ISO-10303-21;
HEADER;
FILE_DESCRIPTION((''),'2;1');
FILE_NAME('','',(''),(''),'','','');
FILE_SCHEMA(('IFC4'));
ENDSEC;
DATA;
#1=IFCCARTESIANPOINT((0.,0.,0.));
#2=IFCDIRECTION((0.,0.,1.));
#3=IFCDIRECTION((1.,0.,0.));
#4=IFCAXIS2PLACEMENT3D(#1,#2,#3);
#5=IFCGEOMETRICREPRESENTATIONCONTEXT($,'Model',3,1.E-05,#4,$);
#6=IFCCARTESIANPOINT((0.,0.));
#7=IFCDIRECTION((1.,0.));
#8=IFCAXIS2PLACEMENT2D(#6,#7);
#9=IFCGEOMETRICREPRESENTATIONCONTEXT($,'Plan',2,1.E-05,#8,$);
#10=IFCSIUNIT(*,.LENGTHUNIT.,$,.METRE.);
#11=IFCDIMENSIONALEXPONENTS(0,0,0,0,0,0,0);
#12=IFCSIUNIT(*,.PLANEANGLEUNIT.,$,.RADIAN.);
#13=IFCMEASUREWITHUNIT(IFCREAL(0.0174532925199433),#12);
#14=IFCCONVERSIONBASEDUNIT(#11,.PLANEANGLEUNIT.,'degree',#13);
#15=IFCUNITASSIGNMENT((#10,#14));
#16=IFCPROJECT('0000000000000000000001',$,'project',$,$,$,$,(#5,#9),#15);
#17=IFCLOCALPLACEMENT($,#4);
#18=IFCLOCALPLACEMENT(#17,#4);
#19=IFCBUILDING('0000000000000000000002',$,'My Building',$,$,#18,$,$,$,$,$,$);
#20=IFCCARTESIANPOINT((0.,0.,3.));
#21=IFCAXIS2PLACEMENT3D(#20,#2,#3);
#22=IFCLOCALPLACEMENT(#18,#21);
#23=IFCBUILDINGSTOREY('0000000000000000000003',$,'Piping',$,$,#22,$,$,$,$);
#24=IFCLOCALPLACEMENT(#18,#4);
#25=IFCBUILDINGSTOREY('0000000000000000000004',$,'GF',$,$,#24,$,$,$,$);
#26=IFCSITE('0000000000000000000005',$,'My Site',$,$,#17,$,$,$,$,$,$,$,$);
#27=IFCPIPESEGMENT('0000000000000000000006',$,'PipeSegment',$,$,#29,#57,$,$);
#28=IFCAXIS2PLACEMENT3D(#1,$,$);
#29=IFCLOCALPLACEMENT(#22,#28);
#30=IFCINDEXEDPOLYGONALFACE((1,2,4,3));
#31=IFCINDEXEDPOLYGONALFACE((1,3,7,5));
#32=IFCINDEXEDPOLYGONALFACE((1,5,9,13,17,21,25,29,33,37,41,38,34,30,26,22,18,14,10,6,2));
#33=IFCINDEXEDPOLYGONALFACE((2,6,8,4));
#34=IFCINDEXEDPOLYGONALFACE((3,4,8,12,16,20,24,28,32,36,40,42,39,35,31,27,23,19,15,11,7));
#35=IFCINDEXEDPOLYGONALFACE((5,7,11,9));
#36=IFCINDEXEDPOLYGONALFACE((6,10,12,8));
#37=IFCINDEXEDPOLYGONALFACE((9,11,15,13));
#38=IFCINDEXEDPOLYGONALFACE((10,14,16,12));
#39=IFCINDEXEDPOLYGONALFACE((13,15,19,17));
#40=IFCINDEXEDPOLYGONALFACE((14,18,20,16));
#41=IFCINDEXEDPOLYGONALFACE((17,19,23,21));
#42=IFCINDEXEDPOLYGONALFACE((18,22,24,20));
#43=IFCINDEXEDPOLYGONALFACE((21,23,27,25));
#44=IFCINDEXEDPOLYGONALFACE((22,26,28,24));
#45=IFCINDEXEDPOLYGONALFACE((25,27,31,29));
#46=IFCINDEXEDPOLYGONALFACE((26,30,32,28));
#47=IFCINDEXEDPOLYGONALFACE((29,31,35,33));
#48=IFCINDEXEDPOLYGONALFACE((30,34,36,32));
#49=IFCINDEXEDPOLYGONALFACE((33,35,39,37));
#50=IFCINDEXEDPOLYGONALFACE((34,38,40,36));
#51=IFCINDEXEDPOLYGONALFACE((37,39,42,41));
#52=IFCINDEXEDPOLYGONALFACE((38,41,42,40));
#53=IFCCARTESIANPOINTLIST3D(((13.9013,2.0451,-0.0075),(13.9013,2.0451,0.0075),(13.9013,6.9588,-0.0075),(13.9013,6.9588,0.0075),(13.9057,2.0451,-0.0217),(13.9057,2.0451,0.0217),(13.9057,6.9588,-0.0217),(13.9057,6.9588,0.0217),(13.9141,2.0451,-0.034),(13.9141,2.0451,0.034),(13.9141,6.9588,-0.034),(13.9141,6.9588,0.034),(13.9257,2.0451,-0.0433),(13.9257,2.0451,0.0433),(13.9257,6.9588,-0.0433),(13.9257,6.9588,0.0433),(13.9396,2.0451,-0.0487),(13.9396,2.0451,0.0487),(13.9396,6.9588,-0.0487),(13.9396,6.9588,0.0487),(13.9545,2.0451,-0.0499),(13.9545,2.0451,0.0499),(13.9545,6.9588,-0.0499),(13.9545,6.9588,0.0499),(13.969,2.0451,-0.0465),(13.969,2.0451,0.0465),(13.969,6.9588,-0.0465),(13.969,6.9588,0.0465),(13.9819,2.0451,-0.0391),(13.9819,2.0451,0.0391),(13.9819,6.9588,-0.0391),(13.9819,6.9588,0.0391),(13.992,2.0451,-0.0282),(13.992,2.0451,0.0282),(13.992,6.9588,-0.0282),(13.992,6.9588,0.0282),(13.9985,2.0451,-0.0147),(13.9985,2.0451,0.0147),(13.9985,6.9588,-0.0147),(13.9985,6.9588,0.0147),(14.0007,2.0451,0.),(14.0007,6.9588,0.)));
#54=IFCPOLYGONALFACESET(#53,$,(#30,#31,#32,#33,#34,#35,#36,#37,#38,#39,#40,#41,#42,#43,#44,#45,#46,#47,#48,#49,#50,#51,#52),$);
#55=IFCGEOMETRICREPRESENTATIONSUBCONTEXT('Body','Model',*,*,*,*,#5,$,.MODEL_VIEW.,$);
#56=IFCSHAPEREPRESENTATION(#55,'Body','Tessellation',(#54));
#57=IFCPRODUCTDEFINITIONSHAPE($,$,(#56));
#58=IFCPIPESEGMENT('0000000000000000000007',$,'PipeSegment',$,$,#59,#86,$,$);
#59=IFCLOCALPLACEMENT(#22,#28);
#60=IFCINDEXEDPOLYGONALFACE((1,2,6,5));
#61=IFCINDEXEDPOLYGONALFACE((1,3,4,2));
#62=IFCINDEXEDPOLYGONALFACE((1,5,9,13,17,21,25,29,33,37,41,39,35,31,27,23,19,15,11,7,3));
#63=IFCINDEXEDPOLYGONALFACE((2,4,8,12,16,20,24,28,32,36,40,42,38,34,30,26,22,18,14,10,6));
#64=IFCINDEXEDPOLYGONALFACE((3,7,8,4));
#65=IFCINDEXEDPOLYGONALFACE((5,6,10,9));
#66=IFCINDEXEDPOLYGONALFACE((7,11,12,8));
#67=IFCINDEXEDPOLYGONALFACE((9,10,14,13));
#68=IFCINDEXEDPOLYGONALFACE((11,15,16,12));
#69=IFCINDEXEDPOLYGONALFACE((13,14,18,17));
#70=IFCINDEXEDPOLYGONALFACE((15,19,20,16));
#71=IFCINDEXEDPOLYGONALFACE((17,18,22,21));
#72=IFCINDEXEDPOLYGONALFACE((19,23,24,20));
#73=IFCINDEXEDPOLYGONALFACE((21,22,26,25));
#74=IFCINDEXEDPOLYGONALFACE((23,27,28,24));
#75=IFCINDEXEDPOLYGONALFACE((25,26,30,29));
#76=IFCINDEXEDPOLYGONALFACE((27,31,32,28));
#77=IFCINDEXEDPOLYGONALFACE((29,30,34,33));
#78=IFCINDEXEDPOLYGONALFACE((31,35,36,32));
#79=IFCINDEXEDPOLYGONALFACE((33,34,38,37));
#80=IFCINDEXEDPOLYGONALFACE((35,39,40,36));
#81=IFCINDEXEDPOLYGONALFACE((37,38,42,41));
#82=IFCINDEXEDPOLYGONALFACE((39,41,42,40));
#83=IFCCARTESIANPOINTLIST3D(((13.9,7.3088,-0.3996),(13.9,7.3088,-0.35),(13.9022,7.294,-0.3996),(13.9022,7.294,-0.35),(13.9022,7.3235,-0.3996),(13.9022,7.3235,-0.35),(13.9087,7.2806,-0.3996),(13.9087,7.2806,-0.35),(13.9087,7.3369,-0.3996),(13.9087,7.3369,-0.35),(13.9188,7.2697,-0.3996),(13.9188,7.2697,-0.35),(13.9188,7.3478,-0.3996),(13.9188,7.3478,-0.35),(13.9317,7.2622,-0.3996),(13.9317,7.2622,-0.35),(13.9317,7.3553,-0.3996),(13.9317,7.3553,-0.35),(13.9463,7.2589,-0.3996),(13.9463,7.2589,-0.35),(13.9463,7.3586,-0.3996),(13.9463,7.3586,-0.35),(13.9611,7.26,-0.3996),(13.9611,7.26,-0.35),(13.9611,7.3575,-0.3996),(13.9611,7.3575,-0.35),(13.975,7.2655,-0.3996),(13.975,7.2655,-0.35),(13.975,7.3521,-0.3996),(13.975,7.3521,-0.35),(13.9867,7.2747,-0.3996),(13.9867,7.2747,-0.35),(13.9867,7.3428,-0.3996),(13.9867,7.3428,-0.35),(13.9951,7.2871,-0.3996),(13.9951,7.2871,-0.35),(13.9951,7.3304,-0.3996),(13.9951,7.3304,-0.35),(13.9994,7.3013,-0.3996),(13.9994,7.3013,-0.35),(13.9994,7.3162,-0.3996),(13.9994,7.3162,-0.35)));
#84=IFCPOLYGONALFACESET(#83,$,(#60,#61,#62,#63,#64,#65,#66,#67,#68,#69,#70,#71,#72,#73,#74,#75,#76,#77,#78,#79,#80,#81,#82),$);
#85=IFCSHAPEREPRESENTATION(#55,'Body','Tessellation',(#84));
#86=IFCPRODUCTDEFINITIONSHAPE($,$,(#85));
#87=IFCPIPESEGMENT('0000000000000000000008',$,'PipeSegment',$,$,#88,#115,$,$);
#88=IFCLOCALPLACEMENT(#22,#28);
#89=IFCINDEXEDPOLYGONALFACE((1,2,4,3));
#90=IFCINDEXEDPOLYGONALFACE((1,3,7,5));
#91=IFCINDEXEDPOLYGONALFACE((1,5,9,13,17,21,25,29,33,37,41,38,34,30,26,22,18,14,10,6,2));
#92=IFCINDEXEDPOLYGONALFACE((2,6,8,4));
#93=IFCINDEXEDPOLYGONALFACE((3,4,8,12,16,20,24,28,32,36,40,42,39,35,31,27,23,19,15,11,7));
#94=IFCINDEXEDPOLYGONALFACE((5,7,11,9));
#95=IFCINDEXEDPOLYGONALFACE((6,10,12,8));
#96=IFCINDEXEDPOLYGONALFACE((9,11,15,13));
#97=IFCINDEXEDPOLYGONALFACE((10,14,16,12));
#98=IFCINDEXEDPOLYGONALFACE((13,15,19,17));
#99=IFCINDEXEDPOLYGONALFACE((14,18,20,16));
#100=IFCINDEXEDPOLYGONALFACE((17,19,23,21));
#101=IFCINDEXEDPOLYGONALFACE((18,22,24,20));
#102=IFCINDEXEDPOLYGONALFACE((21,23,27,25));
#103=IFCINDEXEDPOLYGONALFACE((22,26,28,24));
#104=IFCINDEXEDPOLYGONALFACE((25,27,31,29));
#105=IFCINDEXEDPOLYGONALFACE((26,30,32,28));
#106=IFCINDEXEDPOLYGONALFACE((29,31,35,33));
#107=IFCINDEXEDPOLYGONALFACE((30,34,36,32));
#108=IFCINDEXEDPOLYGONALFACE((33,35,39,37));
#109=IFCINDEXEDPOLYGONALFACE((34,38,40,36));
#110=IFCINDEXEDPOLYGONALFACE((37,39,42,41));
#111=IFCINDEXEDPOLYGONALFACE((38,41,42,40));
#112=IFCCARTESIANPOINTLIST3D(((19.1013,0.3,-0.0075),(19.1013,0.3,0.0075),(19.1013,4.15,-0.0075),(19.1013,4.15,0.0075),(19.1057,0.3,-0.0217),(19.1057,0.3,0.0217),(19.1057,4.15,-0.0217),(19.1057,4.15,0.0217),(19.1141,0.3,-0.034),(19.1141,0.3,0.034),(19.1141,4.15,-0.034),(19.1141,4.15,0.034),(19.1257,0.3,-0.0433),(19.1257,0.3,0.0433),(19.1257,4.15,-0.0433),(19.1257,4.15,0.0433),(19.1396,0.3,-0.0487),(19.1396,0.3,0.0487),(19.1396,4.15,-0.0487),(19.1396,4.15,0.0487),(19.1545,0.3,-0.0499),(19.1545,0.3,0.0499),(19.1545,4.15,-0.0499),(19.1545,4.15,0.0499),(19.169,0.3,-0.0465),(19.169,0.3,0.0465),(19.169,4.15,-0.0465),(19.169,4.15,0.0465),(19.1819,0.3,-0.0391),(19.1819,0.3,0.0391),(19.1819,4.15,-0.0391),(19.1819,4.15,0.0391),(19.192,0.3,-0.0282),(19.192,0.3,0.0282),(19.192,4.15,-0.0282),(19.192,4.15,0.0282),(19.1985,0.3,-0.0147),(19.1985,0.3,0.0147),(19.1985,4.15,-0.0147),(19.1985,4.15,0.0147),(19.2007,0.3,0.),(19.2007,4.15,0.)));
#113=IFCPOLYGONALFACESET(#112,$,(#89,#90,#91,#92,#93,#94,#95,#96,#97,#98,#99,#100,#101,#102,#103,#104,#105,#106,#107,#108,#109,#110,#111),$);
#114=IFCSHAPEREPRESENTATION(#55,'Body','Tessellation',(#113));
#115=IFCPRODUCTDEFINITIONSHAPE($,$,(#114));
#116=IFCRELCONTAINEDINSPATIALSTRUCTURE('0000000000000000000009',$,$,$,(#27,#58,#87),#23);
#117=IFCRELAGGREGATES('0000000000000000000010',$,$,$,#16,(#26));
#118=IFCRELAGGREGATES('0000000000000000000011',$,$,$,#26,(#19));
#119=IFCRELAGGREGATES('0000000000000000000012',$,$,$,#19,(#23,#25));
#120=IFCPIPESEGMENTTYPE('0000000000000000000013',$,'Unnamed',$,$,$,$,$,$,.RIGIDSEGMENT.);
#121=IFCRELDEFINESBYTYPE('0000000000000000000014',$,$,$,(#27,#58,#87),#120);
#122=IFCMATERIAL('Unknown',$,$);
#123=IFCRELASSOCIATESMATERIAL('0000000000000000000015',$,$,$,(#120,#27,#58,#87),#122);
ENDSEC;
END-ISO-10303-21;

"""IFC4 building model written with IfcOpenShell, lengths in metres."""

from ifc_helpers import new_model, entity, si_unit, converted_unit, frame, origin_with_axes, origin_2d_with_axis, place, context, subcontext, project, spatial, circle, extrude, material, material_profile, profile_set, profile_usage, type_object, element, save


model = new_model("IFC4")

# Units and contexts
model_context = context("Model", 3, precision=1e-05, world=origin_with_axes())
plan_context = context("Plan", 2, precision=1e-05, world=origin_2d_with_axis())
body_context_1 = subcontext(model_context, "Body", "Model", "MODEL_VIEW")
ifc_project = project(units=[si_unit("LENGTHUNIT", "METRE"), converted_unit("PLANEANGLEUNIT", "degree", entity("IfcReal", 0.0174532925199433), si_unit("PLANEANGLEUNIT", "RADIAN"), dimensions=[0, 0, 0, 0, 0, 0, 0])], contexts=[model_context, plan_context])

# Site, building, storey
site_placement = place(None, origin_with_axes())
site = spatial("IfcSite", under=ifc_project, at=site_placement, Name="My Site")
building_placement = place(site_placement, origin_with_axes())
building = spatial("IfcBuilding", under=site, at=building_placement, Name="My Building")
storey_1_placement = place(building_placement, frame((0.0, 0.0, 3.0), z_axis=(0.0, 0.0, 1.0), x_axis=(1.0, 0.0, 0.0)))
storey_1 = spatial("IfcBuildingStorey", under=building, at=storey_1_placement, Name="Piping")

# Shared definitions
ifc_material = material(Name="Unknown")

# Shared definitions
storey_2_placement = place(building_placement, origin_with_axes())
storey_2 = spatial("IfcBuildingStorey", under=building, at=storey_2_placement, Name="GF")

# Pipe segments
ifc_material_profile = material_profile(ifc_material, circle(Radius=0.05))
ifc_profile_set = profile_set([ifc_material_profile])
pipe_segment_type = type_object("IfcPipeSegmentType", Name="Unnamed", PredefinedType="RIGIDSEGMENT", material=ifc_profile_set)
ifc_profile_usage_1 = profile_usage(ifc_profile_set, cardinal=5)
pipe_segment_1_placement = place(storey_1_placement, frame((13.9507, 6.9588, 0.0), z_axis=(0.0, -1.0, 0.0), x_axis=(1.0, 0.0, 0.0)))
element("IfcPipeSegment", 1, at=pipe_segment_1_placement, inside=storey_1, type_object=pipe_segment_type, material=ifc_profile_usage_1, Name="PipeSegment", context=body_context_1, shape_type="SweptSolid", body=[
    extrude(circle(Radius=0.05), origin_with_axes(), (0.0, 0.0, 1.0), 4.9137),
])
ifc_profile_usage_2 = profile_usage(ifc_profile_set, cardinal=5)
pipe_segment_2_placement = place(storey_1_placement, frame((13.95, 7.3088, -0.35), z_axis=(0.0, 0.0, -1.0), x_axis=(-1.0, 0.0, 0.0)))
element("IfcPipeSegment", 2, at=pipe_segment_2_placement, inside=storey_1, type_object=pipe_segment_type, material=ifc_profile_usage_2, Name="PipeSegment", context=body_context_1, shape_type="SweptSolid", body=[
    extrude(circle(Radius=0.05), origin_with_axes(), (0.0, 0.0, 1.0), 0.0496),
])
ifc_profile_usage_3 = profile_usage(ifc_profile_set, cardinal=5)
pipe_segment_3_placement = place(storey_1_placement, frame((19.1507, 4.15, 0.0), z_axis=(0.0, -1.0, 0.0), x_axis=(1.0, 0.0, 0.0)))
element("IfcPipeSegment", 3, at=pipe_segment_3_placement, inside=storey_1, type_object=pipe_segment_type, material=ifc_profile_usage_3, Name="PipeSegment", context=body_context_1, shape_type="SweptSolid", body=[
    extrude(circle(Radius=0.05), origin_with_axes(), (0.0, 0.0, 1.0), 3.85),
])

save(model, "model.ifc")
